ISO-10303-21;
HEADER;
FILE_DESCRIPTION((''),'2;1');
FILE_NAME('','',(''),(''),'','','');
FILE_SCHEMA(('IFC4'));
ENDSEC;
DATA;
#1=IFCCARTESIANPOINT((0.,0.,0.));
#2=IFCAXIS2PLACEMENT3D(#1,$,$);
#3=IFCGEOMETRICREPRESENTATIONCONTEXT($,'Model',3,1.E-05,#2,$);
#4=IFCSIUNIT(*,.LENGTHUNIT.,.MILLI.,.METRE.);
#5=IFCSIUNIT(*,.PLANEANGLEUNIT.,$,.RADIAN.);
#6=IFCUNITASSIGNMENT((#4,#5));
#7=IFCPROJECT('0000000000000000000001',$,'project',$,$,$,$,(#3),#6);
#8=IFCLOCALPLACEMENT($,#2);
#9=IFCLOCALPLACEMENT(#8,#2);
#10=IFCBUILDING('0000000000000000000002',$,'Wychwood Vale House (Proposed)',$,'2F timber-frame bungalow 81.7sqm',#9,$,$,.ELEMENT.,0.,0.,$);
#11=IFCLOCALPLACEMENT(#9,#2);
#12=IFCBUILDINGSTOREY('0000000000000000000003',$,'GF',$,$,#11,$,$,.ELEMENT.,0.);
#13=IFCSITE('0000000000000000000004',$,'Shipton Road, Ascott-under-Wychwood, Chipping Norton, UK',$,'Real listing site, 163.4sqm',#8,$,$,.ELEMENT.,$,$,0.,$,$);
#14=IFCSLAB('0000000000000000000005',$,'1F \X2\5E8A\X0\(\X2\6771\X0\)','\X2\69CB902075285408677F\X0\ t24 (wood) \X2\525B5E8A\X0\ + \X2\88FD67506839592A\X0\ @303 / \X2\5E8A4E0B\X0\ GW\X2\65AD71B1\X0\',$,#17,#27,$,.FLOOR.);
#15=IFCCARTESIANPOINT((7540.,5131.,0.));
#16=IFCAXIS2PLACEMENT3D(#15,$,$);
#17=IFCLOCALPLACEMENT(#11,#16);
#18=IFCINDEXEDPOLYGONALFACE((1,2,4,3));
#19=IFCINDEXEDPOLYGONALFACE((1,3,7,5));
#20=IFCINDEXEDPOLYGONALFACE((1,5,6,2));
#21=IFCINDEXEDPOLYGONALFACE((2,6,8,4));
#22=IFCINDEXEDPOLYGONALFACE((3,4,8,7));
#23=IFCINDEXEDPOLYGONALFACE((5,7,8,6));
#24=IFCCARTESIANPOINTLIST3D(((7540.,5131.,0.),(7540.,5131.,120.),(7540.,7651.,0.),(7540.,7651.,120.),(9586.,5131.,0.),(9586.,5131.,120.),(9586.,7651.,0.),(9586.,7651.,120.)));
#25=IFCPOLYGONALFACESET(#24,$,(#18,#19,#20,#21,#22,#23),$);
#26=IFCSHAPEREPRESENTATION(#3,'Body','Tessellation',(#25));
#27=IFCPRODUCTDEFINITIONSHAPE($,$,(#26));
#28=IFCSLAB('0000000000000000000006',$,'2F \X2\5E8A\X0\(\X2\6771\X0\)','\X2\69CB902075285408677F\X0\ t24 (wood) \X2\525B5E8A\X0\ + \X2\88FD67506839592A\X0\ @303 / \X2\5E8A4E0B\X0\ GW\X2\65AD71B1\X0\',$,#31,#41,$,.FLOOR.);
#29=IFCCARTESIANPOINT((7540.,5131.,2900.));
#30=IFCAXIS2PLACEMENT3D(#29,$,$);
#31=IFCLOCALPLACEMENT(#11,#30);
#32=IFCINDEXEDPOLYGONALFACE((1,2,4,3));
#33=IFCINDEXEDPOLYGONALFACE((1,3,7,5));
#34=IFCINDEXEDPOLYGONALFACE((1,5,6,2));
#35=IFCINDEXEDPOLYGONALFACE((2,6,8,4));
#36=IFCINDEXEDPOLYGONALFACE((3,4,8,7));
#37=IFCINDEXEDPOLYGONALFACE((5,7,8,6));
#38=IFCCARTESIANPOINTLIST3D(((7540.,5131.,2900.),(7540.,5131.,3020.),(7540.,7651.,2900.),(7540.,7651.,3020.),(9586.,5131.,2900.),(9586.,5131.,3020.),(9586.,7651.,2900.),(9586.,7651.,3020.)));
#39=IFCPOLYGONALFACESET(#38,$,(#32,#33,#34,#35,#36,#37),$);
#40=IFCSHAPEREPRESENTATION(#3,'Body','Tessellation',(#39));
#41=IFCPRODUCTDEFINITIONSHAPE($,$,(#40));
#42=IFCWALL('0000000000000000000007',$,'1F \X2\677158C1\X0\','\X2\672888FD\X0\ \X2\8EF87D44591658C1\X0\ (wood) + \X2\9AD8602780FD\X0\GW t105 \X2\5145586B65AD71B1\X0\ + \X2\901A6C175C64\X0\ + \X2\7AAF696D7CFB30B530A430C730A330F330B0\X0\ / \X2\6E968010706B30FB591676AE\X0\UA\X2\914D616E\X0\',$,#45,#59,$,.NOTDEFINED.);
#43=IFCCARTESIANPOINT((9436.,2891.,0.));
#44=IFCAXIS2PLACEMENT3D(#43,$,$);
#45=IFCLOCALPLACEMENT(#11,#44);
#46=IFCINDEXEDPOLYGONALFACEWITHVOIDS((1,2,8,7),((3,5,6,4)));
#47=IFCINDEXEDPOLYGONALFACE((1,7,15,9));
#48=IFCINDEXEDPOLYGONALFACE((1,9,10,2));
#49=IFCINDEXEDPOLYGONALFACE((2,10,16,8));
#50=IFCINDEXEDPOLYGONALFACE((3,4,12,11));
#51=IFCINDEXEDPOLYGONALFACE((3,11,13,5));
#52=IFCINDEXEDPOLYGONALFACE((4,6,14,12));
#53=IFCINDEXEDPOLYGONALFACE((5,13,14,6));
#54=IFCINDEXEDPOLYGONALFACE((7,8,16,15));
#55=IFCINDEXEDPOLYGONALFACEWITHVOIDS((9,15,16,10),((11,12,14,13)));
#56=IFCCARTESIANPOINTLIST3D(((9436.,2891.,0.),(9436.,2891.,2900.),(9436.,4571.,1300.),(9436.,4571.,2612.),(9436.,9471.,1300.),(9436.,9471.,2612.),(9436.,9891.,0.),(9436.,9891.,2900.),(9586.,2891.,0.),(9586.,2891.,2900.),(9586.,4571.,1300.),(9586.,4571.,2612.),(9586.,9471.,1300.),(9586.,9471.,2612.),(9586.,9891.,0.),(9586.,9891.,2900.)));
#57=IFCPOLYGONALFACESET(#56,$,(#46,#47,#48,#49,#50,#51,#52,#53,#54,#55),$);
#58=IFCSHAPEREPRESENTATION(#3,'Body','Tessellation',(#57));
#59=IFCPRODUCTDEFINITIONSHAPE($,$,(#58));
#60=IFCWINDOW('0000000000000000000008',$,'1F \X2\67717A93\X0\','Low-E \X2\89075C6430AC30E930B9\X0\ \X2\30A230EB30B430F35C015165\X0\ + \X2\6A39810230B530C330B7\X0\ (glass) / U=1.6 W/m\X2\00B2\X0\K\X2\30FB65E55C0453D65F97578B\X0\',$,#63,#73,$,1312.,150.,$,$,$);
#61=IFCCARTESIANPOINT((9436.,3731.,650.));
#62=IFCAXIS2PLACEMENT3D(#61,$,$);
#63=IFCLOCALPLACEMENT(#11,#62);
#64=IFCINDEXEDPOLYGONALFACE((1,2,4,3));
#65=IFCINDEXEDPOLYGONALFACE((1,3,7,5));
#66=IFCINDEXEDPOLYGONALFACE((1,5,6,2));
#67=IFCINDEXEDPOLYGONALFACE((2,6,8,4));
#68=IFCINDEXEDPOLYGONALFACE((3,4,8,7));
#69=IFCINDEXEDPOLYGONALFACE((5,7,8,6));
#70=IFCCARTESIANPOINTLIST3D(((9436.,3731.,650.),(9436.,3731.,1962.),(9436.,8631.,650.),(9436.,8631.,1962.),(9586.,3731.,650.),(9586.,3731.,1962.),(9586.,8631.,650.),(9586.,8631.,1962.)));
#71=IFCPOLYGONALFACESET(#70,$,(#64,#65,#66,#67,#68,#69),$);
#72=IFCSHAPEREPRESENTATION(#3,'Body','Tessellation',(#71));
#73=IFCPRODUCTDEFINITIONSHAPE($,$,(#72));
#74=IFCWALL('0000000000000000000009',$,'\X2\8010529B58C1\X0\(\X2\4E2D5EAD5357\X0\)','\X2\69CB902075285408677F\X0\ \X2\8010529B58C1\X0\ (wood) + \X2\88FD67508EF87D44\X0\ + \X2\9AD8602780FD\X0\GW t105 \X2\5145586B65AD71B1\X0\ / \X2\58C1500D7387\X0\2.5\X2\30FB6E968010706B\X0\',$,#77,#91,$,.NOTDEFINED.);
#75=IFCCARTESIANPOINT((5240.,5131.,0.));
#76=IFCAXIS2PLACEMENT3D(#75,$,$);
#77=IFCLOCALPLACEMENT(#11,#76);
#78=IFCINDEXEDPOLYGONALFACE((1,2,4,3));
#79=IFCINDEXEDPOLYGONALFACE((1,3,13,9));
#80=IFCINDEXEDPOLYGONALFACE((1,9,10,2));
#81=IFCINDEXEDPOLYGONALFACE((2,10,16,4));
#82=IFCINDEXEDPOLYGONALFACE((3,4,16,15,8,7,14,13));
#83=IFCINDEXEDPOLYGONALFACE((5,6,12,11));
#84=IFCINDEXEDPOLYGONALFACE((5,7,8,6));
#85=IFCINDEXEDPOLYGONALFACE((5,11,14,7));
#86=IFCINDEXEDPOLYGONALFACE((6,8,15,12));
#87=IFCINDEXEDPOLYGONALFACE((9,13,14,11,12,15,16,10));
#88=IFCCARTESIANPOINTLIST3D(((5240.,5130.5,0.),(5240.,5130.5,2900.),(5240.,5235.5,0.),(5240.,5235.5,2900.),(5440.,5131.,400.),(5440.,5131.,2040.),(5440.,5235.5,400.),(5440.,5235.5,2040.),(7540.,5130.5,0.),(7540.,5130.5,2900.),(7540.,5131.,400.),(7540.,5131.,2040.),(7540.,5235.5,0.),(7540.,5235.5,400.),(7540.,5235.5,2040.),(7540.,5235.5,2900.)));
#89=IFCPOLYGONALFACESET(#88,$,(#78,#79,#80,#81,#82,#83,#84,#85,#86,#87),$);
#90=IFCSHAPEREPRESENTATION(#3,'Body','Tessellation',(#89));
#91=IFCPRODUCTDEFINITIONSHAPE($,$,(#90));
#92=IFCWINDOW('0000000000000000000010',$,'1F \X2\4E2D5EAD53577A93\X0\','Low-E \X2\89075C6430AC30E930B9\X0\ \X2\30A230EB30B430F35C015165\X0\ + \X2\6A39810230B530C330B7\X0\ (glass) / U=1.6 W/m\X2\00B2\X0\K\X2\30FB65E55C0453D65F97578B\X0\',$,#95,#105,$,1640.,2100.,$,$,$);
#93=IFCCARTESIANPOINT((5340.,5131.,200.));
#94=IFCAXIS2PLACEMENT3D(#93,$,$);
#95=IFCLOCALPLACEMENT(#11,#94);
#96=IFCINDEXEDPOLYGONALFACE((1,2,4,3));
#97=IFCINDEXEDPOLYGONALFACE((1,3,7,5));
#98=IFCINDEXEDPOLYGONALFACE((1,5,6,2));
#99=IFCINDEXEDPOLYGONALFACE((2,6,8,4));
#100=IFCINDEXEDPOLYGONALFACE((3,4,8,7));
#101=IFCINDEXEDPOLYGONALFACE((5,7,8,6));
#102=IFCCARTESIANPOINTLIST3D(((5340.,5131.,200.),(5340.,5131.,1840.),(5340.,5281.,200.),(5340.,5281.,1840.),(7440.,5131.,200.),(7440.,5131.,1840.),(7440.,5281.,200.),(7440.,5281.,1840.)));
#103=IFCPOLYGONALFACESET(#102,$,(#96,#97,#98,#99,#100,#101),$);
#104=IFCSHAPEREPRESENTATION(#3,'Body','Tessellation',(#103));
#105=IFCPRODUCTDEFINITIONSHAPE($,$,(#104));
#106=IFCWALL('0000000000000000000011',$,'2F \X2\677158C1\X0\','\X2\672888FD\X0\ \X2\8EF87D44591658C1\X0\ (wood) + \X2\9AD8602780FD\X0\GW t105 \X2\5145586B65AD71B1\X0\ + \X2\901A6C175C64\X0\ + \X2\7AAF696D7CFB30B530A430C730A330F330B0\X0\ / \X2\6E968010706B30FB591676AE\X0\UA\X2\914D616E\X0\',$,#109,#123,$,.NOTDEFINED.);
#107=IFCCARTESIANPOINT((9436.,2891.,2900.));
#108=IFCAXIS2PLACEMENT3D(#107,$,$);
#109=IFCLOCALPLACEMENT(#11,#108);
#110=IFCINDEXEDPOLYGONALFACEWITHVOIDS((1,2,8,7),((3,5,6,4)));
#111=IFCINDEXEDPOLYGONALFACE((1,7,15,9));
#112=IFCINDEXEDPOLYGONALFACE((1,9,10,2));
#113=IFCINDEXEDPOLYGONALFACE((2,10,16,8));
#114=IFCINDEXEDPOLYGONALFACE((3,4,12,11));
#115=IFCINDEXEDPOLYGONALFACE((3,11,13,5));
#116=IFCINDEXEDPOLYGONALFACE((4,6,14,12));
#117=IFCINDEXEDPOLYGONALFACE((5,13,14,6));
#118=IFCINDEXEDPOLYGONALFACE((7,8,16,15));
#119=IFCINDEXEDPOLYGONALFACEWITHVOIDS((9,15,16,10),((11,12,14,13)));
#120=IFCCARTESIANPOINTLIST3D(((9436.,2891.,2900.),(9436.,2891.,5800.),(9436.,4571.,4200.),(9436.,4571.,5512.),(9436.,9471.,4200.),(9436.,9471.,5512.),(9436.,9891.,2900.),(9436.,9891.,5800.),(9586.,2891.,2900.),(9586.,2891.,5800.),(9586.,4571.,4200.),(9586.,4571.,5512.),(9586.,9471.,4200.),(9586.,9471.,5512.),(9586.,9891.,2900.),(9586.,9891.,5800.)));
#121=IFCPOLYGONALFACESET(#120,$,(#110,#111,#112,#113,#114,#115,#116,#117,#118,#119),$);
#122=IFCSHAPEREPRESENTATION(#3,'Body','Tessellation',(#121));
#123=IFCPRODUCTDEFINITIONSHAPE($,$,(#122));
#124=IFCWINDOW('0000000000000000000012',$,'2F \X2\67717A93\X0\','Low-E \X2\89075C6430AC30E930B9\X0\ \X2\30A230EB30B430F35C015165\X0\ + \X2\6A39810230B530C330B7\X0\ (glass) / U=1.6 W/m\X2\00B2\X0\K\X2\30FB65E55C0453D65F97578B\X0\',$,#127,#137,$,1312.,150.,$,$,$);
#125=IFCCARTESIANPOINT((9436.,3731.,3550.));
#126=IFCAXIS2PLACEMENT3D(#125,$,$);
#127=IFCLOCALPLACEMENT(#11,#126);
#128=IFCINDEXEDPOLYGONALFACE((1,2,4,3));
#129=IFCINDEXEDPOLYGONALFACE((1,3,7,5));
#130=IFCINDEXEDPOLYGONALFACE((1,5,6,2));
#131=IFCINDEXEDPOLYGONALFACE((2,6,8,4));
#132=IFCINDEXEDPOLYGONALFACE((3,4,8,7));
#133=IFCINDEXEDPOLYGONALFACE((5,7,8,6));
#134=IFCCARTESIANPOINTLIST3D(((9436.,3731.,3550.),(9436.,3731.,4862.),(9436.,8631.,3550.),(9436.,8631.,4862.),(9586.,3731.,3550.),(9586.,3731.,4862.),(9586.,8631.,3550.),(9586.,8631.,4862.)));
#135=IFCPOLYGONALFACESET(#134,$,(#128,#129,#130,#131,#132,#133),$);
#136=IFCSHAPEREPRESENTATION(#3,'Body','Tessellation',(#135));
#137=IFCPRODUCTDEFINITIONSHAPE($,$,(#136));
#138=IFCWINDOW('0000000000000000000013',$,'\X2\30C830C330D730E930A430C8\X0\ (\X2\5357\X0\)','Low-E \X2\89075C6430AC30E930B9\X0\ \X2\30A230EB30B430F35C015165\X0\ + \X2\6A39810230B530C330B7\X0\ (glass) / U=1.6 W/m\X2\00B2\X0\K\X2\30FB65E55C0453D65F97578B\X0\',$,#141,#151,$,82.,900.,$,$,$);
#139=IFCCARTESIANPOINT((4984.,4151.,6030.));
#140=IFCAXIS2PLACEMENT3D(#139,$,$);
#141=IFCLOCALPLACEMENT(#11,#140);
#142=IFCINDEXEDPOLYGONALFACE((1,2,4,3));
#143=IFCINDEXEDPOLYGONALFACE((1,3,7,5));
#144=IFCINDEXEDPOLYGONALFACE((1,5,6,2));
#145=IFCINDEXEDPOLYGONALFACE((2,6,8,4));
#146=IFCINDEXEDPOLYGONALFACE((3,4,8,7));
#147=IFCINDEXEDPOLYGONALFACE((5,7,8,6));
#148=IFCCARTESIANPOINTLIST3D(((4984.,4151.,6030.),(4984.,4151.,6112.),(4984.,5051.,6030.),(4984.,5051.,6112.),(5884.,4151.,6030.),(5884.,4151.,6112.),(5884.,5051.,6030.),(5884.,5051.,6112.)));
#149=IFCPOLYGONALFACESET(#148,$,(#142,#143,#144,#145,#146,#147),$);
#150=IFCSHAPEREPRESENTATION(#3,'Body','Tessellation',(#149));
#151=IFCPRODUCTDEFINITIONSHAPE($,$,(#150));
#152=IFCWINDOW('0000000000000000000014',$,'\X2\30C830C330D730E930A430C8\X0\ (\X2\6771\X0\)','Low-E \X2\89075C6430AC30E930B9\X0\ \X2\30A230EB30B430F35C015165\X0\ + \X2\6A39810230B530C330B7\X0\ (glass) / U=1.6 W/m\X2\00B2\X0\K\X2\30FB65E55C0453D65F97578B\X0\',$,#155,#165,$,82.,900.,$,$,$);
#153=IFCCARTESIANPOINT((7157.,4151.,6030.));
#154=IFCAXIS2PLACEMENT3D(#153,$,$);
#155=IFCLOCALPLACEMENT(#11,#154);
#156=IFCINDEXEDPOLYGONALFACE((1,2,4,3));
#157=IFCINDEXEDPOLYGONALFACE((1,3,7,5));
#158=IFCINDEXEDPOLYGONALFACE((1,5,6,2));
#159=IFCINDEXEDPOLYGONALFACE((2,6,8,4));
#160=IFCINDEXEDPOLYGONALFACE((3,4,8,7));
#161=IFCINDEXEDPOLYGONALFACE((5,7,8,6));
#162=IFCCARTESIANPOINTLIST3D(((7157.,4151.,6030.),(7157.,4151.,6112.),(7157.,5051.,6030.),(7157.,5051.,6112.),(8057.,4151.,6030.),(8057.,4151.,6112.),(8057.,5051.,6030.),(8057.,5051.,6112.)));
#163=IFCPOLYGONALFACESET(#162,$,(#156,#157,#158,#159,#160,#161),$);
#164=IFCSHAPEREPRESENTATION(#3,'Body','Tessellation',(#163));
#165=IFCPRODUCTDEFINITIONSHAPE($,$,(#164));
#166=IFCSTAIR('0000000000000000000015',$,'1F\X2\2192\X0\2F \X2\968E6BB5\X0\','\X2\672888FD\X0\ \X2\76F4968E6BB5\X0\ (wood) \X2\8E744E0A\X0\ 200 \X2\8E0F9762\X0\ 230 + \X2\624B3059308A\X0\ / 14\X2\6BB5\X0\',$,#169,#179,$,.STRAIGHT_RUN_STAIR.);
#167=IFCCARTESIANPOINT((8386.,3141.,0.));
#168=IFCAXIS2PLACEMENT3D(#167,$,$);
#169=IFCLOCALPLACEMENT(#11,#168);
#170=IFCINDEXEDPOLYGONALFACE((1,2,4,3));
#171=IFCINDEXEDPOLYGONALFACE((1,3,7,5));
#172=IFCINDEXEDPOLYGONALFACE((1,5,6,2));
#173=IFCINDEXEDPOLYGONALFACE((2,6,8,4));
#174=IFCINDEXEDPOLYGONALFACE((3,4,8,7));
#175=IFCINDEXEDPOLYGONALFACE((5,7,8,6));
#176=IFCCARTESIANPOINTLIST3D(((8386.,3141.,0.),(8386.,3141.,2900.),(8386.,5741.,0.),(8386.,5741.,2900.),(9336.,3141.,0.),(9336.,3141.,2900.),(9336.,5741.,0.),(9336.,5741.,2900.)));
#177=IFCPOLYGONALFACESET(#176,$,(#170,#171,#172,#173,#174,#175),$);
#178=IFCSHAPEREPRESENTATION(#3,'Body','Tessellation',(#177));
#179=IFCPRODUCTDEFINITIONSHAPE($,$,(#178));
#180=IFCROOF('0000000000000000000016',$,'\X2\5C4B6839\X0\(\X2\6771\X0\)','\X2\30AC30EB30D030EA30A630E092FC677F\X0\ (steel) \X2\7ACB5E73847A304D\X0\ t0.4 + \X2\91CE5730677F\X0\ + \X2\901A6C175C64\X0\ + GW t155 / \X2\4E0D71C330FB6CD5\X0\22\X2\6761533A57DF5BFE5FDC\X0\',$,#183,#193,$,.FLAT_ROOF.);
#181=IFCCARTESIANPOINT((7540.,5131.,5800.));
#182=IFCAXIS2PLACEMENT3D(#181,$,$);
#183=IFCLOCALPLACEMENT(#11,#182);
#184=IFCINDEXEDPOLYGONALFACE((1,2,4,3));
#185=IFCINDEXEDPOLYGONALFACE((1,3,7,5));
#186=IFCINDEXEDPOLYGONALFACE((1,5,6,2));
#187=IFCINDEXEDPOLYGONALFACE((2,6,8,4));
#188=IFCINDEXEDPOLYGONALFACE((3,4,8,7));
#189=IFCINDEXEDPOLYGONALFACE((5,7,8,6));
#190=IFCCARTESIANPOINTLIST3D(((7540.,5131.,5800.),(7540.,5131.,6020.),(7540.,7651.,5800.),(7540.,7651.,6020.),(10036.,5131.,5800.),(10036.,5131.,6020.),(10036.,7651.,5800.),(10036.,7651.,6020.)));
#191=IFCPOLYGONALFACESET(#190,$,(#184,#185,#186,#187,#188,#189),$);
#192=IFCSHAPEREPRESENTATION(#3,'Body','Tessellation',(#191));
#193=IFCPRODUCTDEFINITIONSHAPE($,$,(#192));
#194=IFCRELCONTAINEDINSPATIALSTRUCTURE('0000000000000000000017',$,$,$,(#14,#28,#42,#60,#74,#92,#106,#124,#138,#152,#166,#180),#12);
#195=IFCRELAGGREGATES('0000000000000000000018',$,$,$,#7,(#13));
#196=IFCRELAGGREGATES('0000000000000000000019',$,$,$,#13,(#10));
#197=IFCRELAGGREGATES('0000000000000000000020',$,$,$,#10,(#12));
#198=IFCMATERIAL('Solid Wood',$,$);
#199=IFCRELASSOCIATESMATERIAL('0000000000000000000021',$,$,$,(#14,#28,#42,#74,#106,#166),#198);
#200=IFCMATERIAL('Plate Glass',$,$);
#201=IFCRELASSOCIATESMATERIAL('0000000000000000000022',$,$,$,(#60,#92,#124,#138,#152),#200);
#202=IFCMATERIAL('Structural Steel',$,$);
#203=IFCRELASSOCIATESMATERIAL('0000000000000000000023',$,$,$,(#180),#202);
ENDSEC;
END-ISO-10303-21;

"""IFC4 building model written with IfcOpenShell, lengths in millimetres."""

from ifc_helpers import new_model, si_unit, frame, frame_2d, origin, place, context, project, spatial, rectangle, extrude, material, element, fill, save


model = new_model("IFC4")

# Units and contexts
model_context = context("Model", 3, precision=1e-05, world=origin())
ifc_project = project(units=[si_unit("LENGTHUNIT", "METRE", prefix="MILLI"), si_unit("PLANEANGLEUNIT", "RADIAN")], contexts=[model_context])

# Site, building, storey
site_placement = place(None, origin())
site = spatial("IfcSite", under=ifc_project, at=site_placement, Name="Shipton Road, Ascott-under-Wychwood, Chipping Norton, UK", ObjectType="Real listing site, 163.4sqm", CompositionType="ELEMENT", RefElevation=0.0)
building_placement = place(site_placement, origin())
building = spatial("IfcBuilding", under=site, at=building_placement, Name="Wychwood Vale House (Proposed)", ObjectType="2F timber-frame bungalow 81.7sqm", CompositionType="ELEMENT", ElevationOfRefHeight=0.0, ElevationOfTerrain=0.0)
storey_placement = place(building_placement, origin())
storey = spatial("IfcBuildingStorey", under=building, at=storey_placement, Name="GF", CompositionType="ELEMENT", Elevation=0.0)

# Slabs
ifc_material_1 = material(Name="Solid Wood")
slab_1_placement = place(storey_placement, frame((7540.0, 5131.0, 0.0)))
element("IfcSlab", 1, at=slab_1_placement, inside=storey, material=ifc_material_1, Name="1F 床(東)", Description="構造用合板 t24 (wood) 剛床 + 製材根太 @303 / 床下 GW断熱", PredefinedType="FLOOR", context=model_context, shape_type="SweptSolid", body=[
    extrude(rectangle(XDim=2046.0, YDim=2520.0, at=frame_2d((1023.0, 1260.0))), frame((7540.0, 5131.0, 0.0)), (0.0, 0.0, 1.0), 120.0),
])
slab_2_placement = place(storey_placement, frame((7540.0, 5131.0, 2900.0)))
element("IfcSlab", 2, at=slab_2_placement, inside=storey, material=ifc_material_1, Name="2F 床(東)", Description="構造用合板 t24 (wood) 剛床 + 製材根太 @303 / 床下 GW断熱", PredefinedType="FLOOR", context=model_context, shape_type="SweptSolid", body=[
    extrude(rectangle(XDim=2046.0, YDim=2520.0, at=frame_2d((1023.0, 1260.0))), frame((7540.0, 5131.0, 2900.0)), (0.0, 0.0, 1.0), 120.0),
])

# Walls, openings, windows
wall_1_placement = place(storey_placement, frame((9436.0, 2891.0, 0.0)))
wall_1 = element("IfcWall", 3, at=wall_1_placement, inside=storey, material=ifc_material_1, Name="1F 東壁", Description="木製 軸組外壁 (wood) + 高性能GW t105 充填断熱 + 通気層 + 窯業系サイディング / 準耐火・外皮UA配慮", PredefinedType="NOTDEFINED", context=model_context, shape_type="SweptSolid", body=[
    extrude(rectangle(XDim=150.0, YDim=7000.0, at=frame_2d((75.0, 3500.0))), frame((9436.0, 2891.0, 0.0)), (0.0, 0.0, 1.0), 2900.0),
])
opening_1_placement = place(storey_placement, frame((9436.0, 3731.0, 650.0)))
opening_1 = element("IfcOpeningElement", 4, at=opening_1_placement, cuts=wall_1, PredefinedType="NOTDEFINED", context=model_context, shape_type="SweptSolid", body=[
    extrude(rectangle(XDim=150.0, YDim=4900.0, at=frame_2d((75.0, 2450.0))), frame((9436.0, 3731.0, 650.0)), (0.0, 0.0, 1.0), 1312.0),
])
ifc_material_2 = material(Name="Plate Glass")
window_1_placement = place(storey_placement, frame((9436.0, 3731.0, 650.0)))
window_1 = element("IfcWindow", 5, at=window_1_placement, inside=storey, material=ifc_material_2, Name="1F 東窓", Description="Low-E 複層ガラス アルゴン封入 + 樹脂サッシ (glass) / U=1.6 W/m²K・日射取得型", OverallHeight=1312.0, OverallWidth=150.0, context=model_context, shape_type="SweptSolid", body=[
    extrude(rectangle(XDim=150.0, YDim=4900.0, at=frame_2d((75.0, 2450.0))), frame((9436.0, 3731.0, 650.0)), (0.0, 0.0, 1.0), 1312.0),
])
fill(opening_1, window_1)
wall_2_placement = place(storey_placement, frame((5240.0, 5131.0, 0.0)))
wall_2 = element("IfcWall", 6, at=wall_2_placement, inside=storey, material=ifc_material_1, Name="耐力壁(中庭南)", Description="構造用合板 耐力壁 (wood) + 製材軸組 + 高性能GW t105 充填断熱 / 壁倍率2.5・準耐火", PredefinedType="NOTDEFINED", context=model_context, shape_type="SweptSolid", body=[
    extrude(rectangle(XDim=2300.0, YDim=105.0, at=frame_2d((1150.0, 52.0))), frame((5240.0, 5131.0, 0.0)), (0.0, 0.0, 1.0), 2900.0),
])
opening_2_placement = place(storey_placement, frame((5340.0, 5131.0, 200.0)))
opening_2 = element("IfcOpeningElement", 7, at=opening_2_placement, cuts=wall_2, PredefinedType="NOTDEFINED", context=model_context, shape_type="SweptSolid", body=[
    extrude(rectangle(XDim=2100.0, YDim=150.0, at=frame_2d((1050.0, 75.0))), frame((5340.0, 5131.0, 200.0)), (0.0, 0.0, 1.0), 1640.0),
])
window_2_placement = place(storey_placement, frame((5340.0, 5131.0, 200.0)))
window_2 = element("IfcWindow", 8, at=window_2_placement, inside=storey, material=ifc_material_2, Name="1F 中庭南窓", Description="Low-E 複層ガラス アルゴン封入 + 樹脂サッシ (glass) / U=1.6 W/m²K・日射取得型", OverallHeight=1640.0, OverallWidth=2100.0, context=model_context, shape_type="SweptSolid", body=[
    extrude(rectangle(XDim=2100.0, YDim=150.0, at=frame_2d((1050.0, 75.0))), frame((5340.0, 5131.0, 200.0)), (0.0, 0.0, 1.0), 1640.0),
])
fill(opening_2, window_2)

# Wall, opening, window
wall_3_placement = place(storey_placement, frame((9436.0, 2891.0, 2900.0)))
wall_3 = element("IfcWall", 9, at=wall_3_placement, inside=storey, material=ifc_material_1, Name="2F 東壁", Description="木製 軸組外壁 (wood) + 高性能GW t105 充填断熱 + 通気層 + 窯業系サイディング / 準耐火・外皮UA配慮", PredefinedType="NOTDEFINED", context=model_context, shape_type="SweptSolid", body=[
    extrude(rectangle(XDim=150.0, YDim=7000.0, at=frame_2d((75.0, 3500.0))), frame((9436.0, 2891.0, 2900.0)), (0.0, 0.0, 1.0), 2900.0),
])
opening_3_placement = place(storey_placement, frame((9436.0, 3731.0, 3550.0)))
opening_3 = element("IfcOpeningElement", 10, at=opening_3_placement, cuts=wall_3, PredefinedType="NOTDEFINED", context=model_context, shape_type="SweptSolid", body=[
    extrude(rectangle(XDim=150.0, YDim=4900.0, at=frame_2d((75.0, 2450.0))), frame((9436.0, 3731.0, 3550.0)), (0.0, 0.0, 1.0), 1312.0),
])
window_3_placement = place(storey_placement, frame((9436.0, 3731.0, 3550.0)))
window_3 = element("IfcWindow", 11, at=window_3_placement, inside=storey, material=ifc_material_2, Name="2F 東窓", Description="Low-E 複層ガラス アルゴン封入 + 樹脂サッシ (glass) / U=1.6 W/m²K・日射取得型", OverallHeight=1312.0, OverallWidth=150.0, context=model_context, shape_type="SweptSolid", body=[
    extrude(rectangle(XDim=150.0, YDim=4900.0, at=frame_2d((75.0, 2450.0))), frame((9436.0, 3731.0, 3550.0)), (0.0, 0.0, 1.0), 1312.0),
])
fill(opening_3, window_3)

# Windows
window_4_placement = place(storey_placement, frame((4984.0, 4151.0, 6030.0)))
element("IfcWindow", 12, at=window_4_placement, inside=storey, material=ifc_material_2, Name="トップライト (南)", Description="Low-E 複層ガラス アルゴン封入 + 樹脂サッシ (glass) / U=1.6 W/m²K・日射取得型", OverallHeight=82.0, OverallWidth=900.0, context=model_context, shape_type="SweptSolid", body=[
    extrude(rectangle(XDim=900.0, YDim=900.0, at=frame_2d((450.0, 450.0))), frame((4984.0, 4151.0, 6030.0)), (0.0, 0.0, 1.0), 82.0),
])
window_5_placement = place(storey_placement, frame((7157.0, 4151.0, 6030.0)))
element("IfcWindow", 13, at=window_5_placement, inside=storey, material=ifc_material_2, Name="トップライト (東)", Description="Low-E 複層ガラス アルゴン封入 + 樹脂サッシ (glass) / U=1.6 W/m²K・日射取得型", OverallHeight=82.0, OverallWidth=900.0, context=model_context, shape_type="SweptSolid", body=[
    extrude(rectangle(XDim=900.0, YDim=900.0, at=frame_2d((450.0, 450.0))), frame((7157.0, 4151.0, 6030.0)), (0.0, 0.0, 1.0), 82.0),
])

# Stair
stair_placement = place(storey_placement, frame((8386.0, 3141.0, 0.0)))
element("IfcStair", 14, at=stair_placement, inside=storey, material=ifc_material_1, Name="1F→2F 階段", Description="木製 直階段 (wood) 蹴上 200 踏面 230 + 手すり / 14段", PredefinedType="STRAIGHT_RUN_STAIR", context=model_context, shape_type="SweptSolid", body=[
    extrude(rectangle(XDim=950.0, YDim=2600.0, at=frame_2d((475.0, 1300.0))), frame((8386.0, 3141.0, 0.0)), (0.0, 0.0, 1.0), 2900.0),
])

# Roof
ifc_material_3 = material(Name="Structural Steel")
roof_placement = place(storey_placement, frame((7540.0, 5131.0, 5800.0)))
element("IfcRoof", 15, at=roof_placement, inside=storey, material=ifc_material_3, Name="屋根(東)", Description="ガルバリウム鋼板 (steel) 立平葺き t0.4 + 野地板 + 通気層 + GW t155 / 不燃・法22条区域対応", PredefinedType="FLAT_ROOF", context=model_context, shape_type="SweptSolid", body=[
    extrude(rectangle(XDim=2496.0, YDim=2520.0, at=frame_2d((1248.0, 1260.0))), frame((7540.0, 5131.0, 5800.0)), (0.0, 0.0, 1.0), 220.0),
])

save(model, "model.ifc")
